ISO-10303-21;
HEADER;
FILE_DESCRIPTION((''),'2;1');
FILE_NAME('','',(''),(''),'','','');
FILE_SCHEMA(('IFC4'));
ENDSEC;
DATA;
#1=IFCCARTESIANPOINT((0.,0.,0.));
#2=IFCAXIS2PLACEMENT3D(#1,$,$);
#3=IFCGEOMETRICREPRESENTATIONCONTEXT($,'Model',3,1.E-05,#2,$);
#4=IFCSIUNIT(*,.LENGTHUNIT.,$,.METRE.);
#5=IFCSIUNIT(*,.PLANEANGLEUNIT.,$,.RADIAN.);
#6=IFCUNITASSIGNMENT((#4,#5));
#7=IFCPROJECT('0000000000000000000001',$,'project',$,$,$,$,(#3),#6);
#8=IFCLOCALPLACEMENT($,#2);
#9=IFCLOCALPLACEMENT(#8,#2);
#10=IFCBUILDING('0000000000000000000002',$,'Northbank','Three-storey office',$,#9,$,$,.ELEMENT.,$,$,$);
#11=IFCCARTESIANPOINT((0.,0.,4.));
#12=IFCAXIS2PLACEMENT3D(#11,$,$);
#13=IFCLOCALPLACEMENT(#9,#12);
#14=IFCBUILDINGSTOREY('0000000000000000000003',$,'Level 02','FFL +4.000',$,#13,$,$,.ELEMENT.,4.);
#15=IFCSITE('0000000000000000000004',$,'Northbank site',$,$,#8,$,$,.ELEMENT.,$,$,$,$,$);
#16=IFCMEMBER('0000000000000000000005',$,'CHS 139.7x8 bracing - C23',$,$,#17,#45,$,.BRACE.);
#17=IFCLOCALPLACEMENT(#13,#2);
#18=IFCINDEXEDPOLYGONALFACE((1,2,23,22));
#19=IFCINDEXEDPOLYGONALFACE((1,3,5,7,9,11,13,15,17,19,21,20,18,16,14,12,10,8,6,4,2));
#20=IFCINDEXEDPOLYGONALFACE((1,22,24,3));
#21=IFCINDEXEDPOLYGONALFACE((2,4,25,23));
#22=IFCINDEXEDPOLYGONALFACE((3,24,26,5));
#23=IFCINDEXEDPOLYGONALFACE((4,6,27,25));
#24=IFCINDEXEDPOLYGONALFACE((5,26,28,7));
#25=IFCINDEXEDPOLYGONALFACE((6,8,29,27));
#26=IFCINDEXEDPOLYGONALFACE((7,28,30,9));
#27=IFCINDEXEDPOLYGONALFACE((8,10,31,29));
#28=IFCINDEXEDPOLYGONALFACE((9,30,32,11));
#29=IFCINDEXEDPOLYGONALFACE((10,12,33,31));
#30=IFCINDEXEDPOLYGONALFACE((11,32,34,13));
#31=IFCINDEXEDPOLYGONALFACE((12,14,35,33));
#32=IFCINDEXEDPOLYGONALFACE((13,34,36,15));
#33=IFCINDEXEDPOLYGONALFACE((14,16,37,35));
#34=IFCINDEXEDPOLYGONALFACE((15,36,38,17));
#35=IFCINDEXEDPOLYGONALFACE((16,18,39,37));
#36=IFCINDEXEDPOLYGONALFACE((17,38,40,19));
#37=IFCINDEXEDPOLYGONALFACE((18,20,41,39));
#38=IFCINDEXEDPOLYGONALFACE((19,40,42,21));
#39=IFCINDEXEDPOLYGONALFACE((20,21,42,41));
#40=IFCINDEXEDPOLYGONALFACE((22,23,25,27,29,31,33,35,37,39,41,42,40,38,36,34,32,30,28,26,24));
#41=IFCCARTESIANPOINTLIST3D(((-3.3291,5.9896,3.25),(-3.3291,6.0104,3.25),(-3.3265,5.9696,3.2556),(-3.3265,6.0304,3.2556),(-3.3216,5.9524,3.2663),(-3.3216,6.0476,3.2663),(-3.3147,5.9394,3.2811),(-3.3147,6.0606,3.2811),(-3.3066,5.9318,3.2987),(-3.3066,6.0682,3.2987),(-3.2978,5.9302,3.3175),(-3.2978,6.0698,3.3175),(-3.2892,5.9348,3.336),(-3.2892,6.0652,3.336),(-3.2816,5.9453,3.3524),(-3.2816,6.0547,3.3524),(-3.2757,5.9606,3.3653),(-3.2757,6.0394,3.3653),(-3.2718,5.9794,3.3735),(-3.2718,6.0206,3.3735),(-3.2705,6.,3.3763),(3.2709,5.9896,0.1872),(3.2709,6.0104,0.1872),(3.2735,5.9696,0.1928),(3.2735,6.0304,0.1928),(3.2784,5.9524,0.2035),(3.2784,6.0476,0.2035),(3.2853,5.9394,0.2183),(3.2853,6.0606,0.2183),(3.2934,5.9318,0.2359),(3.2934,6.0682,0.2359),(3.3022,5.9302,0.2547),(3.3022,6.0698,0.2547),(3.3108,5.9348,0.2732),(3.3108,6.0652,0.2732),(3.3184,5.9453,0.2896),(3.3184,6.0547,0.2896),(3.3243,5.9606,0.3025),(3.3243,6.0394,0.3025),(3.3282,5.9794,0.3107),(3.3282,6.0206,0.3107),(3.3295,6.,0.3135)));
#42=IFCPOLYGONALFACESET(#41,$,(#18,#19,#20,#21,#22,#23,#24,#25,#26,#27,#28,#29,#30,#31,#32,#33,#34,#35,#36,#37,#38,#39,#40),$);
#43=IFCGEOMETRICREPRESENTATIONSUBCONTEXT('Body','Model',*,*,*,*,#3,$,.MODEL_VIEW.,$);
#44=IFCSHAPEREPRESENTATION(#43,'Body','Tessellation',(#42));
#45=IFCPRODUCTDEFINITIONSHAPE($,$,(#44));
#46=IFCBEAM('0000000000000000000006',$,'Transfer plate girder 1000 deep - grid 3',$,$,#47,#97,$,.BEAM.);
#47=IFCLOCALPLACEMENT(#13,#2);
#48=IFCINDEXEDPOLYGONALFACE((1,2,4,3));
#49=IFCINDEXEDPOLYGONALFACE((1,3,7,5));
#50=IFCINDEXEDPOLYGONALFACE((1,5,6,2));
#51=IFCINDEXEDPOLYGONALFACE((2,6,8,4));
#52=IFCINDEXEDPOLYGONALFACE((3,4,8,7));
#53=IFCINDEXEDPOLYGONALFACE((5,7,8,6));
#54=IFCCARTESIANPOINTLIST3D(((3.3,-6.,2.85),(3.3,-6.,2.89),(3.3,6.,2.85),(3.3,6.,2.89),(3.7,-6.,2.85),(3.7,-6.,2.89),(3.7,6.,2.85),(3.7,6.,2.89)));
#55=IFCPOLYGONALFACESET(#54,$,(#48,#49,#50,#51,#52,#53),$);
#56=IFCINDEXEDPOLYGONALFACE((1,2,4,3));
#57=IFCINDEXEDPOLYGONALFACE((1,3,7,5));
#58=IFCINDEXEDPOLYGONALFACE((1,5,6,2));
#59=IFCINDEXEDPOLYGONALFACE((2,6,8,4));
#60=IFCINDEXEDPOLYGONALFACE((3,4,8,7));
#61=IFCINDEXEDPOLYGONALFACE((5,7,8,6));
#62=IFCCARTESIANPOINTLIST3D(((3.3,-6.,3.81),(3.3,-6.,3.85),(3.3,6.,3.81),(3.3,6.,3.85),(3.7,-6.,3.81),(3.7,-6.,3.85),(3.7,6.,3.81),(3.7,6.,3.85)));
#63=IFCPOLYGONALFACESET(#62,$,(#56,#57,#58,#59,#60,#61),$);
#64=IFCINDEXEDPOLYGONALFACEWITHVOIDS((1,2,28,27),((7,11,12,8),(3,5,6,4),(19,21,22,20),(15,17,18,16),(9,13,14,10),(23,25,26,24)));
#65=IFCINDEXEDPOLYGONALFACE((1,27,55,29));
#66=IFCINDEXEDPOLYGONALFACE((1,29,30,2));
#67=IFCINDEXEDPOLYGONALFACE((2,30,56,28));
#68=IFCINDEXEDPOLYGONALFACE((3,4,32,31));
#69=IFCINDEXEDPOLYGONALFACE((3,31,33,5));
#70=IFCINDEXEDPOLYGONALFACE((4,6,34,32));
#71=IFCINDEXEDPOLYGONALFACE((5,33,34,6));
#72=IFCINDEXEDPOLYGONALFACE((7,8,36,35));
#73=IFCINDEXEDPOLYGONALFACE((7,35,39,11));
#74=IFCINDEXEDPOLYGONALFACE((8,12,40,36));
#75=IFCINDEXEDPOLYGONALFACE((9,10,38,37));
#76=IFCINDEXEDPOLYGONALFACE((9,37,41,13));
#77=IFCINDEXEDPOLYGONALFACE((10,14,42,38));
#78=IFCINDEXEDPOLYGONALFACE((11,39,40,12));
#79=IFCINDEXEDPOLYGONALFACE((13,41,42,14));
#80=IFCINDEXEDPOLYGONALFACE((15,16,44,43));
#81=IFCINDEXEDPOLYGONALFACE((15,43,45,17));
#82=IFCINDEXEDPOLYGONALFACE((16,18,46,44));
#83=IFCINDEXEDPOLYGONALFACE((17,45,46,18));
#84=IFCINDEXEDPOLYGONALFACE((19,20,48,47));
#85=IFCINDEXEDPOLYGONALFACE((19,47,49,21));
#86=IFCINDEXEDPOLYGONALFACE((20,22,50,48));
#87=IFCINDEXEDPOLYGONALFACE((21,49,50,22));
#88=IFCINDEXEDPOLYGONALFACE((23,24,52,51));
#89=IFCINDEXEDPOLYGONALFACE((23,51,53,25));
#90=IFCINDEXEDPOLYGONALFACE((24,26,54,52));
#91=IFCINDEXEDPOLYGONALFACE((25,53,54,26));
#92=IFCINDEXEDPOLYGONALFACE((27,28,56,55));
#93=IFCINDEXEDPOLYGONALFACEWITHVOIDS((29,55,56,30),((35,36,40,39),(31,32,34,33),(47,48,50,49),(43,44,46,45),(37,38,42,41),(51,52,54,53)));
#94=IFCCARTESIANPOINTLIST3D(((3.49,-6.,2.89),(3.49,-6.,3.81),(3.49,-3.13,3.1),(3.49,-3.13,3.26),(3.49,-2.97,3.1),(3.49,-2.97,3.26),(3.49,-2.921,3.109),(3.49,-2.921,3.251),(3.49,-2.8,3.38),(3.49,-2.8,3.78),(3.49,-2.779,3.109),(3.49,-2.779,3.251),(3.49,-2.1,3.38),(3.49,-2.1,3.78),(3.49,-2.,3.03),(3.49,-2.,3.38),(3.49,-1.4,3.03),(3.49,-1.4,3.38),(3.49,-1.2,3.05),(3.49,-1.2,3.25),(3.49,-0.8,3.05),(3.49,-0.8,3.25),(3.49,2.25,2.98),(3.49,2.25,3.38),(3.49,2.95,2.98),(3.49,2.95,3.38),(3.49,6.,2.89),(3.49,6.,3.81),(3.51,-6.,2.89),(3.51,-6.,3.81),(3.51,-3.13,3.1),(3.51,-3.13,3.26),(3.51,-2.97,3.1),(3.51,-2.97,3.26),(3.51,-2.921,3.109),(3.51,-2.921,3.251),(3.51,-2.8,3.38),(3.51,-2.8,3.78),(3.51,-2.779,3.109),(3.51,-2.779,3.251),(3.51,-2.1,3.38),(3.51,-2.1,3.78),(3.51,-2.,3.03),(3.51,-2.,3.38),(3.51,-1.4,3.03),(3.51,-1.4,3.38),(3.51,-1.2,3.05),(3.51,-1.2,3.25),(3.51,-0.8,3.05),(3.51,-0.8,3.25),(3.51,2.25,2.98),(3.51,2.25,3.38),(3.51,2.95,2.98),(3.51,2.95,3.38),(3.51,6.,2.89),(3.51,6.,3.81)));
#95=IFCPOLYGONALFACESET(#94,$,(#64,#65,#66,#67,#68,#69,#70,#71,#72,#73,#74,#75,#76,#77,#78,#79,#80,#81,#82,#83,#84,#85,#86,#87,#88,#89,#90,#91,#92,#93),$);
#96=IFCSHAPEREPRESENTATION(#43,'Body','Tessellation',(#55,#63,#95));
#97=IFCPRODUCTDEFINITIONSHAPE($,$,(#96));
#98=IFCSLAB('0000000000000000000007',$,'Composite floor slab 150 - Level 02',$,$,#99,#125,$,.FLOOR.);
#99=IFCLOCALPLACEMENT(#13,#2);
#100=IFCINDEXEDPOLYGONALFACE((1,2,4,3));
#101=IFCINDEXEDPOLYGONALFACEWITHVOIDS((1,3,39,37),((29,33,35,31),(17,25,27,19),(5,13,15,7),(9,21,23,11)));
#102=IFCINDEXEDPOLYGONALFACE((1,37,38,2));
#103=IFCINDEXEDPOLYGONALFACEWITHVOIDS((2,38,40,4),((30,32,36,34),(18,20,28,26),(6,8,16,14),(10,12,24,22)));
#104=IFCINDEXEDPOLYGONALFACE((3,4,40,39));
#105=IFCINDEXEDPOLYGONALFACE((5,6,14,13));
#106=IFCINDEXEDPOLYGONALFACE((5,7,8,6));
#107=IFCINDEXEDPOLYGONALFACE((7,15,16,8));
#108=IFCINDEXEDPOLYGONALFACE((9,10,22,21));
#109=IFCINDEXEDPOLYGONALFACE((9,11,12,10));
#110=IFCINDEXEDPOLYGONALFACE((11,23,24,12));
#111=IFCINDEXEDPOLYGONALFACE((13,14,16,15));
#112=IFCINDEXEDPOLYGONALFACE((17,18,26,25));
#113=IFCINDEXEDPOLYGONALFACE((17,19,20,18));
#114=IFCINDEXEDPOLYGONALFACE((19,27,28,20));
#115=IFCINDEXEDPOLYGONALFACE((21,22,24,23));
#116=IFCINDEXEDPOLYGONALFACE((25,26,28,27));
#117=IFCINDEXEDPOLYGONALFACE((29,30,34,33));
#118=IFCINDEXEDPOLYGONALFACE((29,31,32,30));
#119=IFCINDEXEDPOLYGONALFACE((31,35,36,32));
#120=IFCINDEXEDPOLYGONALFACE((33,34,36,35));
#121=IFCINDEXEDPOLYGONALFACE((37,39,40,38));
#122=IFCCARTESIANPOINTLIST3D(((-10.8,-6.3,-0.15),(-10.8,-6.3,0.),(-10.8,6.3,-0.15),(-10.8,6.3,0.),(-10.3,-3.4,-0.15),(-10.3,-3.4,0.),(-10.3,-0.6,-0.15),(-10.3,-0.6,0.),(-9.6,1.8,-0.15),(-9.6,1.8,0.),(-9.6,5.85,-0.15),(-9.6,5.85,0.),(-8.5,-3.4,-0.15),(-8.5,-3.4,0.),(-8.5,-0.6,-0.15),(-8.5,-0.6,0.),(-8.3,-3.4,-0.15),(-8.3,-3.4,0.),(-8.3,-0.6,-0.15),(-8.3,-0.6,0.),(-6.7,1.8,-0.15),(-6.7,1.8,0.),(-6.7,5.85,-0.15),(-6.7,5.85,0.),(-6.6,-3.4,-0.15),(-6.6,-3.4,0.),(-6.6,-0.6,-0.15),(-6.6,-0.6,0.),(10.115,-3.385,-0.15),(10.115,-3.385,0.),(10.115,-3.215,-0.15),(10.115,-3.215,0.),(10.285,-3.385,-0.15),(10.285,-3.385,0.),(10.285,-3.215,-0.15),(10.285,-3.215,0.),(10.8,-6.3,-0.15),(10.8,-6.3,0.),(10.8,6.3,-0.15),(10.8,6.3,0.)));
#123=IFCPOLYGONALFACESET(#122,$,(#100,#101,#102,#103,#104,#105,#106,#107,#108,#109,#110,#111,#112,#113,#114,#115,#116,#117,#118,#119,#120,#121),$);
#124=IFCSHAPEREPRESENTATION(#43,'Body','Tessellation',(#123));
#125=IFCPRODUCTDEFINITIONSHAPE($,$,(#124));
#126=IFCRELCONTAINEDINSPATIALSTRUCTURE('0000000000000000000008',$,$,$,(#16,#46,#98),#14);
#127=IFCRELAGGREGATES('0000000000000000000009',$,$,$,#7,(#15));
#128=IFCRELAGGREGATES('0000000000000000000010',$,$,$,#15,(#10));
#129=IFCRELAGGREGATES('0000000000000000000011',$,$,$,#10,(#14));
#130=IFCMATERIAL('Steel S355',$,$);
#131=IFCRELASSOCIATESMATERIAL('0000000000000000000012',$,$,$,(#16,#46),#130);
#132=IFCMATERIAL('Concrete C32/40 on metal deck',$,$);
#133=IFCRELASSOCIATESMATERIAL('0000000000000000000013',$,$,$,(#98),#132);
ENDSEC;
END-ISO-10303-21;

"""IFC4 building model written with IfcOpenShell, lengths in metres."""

from ifc_helpers import new_model, si_unit, frame, origin, place, context, subcontext, project, spatial, polyline, rectangle, circle, outline, extrude, material, element, save


model = new_model("IFC4")

# Units and contexts
model_context = context("Model", 3, precision=1e-05, world=origin())
body_context = subcontext(model_context, "Body", "Model", "MODEL_VIEW")
ifc_project = project(units=[si_unit("LENGTHUNIT", "METRE"), si_unit("PLANEANGLEUNIT", "RADIAN")], contexts=[model_context])

# Site, building, storey
site_placement = place(None, origin())
site = spatial("IfcSite", under=ifc_project, at=site_placement, Name="Northbank site", CompositionType="ELEMENT")
building_placement = place(site_placement, origin())
building = spatial("IfcBuilding", under=site, at=building_placement, Name="Northbank", Description="Three-storey office", CompositionType="ELEMENT")
storey_placement = place(building_placement, frame((0.0, 0.0, 4.0)))
storey = spatial("IfcBuildingStorey", under=building, at=storey_placement, Name="Level 02", Description="FFL +4.000", CompositionType="ELEMENT", Elevation=4.0)

# Shared definitions
ifc_material_1 = material(Name="Steel S355")

# Member
member_1_placement = place(storey_placement, frame((0.0, 0.0, -4.0)))
element("IfcMember", 1, at=member_1_placement, inside=storey, material=ifc_material_1, Name="CHS 139.7x8 bracing - C23", PredefinedType="BRACE", context=body_context, shape_type="SweptSolid", body=[
    extrude(circle(Radius=0.07), frame((3.3, 6.0, 4.25), z_axis=(-0.907087, 0.0, 0.420943), x_axis=(0.420943, 0.0, 0.907087)), (0.0, 0.0, 1.0), 7.276),
])

# Beam
beam_1_placement = place(storey_placement, frame((0.0, 0.0, -4.0)))
element("IfcBeam", 2, at=beam_1_placement, inside=storey, material=ifc_material_1, Name="Transfer plate girder 1000 deep - grid 3", PredefinedType="BEAM", context=body_context, shape_type="SweptSolid", body=[
    extrude(rectangle(XDim=0.4, YDim=12.0), frame((3.5, 0.0, 6.85)), (0.0, 0.0, 1.0), 0.04),
    extrude(rectangle(XDim=0.4, YDim=12.0), frame((3.5, 0.0, 7.81)), (0.0, 0.0, 1.0), 0.04),
    extrude(outline(polyline([(0.0, 0.0), (12.0, 0.0), (12.0, 0.92), (0.0, 0.92), (0.0, 0.0)]), holes=[polyline([(8.25, 0.09), (8.25, 0.49), (8.95, 0.49), (8.95, 0.09), (8.25, 0.09)]), polyline([(4.0, 0.14), (4.0, 0.49), (4.6, 0.49), (4.6, 0.14), (4.0, 0.14)]), polyline([(3.079, 0.219), (3.079, 0.361), (3.221, 0.361), (3.221, 0.219), (3.079, 0.219)]), polyline([(3.2, 0.49), (3.2, 0.89), (3.9, 0.89), (3.9, 0.49), (3.2, 0.49)]), polyline([(4.8, 0.16), (4.8, 0.36), (5.2, 0.36), (5.2, 0.16), (4.8, 0.16)]), polyline([(2.87, 0.21), (2.87, 0.37), (3.03, 0.37), (3.03, 0.21), (2.87, 0.21)])]), frame((3.49, -6.0, 6.89), z_axis=(1.0, 0.0, 0.0), x_axis=(0.0, 1.0, 0.0)), (0.0, 0.0, 1.0), 0.02),
])

# Slab
ifc_material_2 = material(Name="Concrete C32/40 on metal deck")
slab_placement = place(storey_placement, frame((0.0, 0.0, -4.0)))
element("IfcSlab", 3, at=slab_placement, inside=storey, material=ifc_material_2, Name="Composite floor slab 150 - Level 02", PredefinedType="FLOOR", context=body_context, shape_type="SweptSolid", body=[
    extrude(outline(polyline([(-10.8, -6.3), (10.8, -6.3), (10.8, 6.3), (-10.8, 6.3), (-10.8, -6.3)]), holes=[polyline([(-10.3, -3.4), (-10.3, -0.6), (-8.5, -0.6), (-8.5, -3.4), (-10.3, -3.4)]), polyline([(-8.3, -3.4), (-8.3, -0.6), (-6.6, -0.6), (-6.6, -3.4), (-8.3, -3.4)]), polyline([(-9.6, 1.8), (-9.6, 5.85), (-6.7, 5.85), (-6.7, 1.8), (-9.6, 1.8)]), polyline([(10.115, -3.385), (10.115, -3.215), (10.285, -3.215), (10.285, -3.385), (10.115, -3.385)])]), frame((0.0, 0.0, 3.85)), (0.0, 0.0, 1.0), 0.15),
])

save(model, "model.ifc")
